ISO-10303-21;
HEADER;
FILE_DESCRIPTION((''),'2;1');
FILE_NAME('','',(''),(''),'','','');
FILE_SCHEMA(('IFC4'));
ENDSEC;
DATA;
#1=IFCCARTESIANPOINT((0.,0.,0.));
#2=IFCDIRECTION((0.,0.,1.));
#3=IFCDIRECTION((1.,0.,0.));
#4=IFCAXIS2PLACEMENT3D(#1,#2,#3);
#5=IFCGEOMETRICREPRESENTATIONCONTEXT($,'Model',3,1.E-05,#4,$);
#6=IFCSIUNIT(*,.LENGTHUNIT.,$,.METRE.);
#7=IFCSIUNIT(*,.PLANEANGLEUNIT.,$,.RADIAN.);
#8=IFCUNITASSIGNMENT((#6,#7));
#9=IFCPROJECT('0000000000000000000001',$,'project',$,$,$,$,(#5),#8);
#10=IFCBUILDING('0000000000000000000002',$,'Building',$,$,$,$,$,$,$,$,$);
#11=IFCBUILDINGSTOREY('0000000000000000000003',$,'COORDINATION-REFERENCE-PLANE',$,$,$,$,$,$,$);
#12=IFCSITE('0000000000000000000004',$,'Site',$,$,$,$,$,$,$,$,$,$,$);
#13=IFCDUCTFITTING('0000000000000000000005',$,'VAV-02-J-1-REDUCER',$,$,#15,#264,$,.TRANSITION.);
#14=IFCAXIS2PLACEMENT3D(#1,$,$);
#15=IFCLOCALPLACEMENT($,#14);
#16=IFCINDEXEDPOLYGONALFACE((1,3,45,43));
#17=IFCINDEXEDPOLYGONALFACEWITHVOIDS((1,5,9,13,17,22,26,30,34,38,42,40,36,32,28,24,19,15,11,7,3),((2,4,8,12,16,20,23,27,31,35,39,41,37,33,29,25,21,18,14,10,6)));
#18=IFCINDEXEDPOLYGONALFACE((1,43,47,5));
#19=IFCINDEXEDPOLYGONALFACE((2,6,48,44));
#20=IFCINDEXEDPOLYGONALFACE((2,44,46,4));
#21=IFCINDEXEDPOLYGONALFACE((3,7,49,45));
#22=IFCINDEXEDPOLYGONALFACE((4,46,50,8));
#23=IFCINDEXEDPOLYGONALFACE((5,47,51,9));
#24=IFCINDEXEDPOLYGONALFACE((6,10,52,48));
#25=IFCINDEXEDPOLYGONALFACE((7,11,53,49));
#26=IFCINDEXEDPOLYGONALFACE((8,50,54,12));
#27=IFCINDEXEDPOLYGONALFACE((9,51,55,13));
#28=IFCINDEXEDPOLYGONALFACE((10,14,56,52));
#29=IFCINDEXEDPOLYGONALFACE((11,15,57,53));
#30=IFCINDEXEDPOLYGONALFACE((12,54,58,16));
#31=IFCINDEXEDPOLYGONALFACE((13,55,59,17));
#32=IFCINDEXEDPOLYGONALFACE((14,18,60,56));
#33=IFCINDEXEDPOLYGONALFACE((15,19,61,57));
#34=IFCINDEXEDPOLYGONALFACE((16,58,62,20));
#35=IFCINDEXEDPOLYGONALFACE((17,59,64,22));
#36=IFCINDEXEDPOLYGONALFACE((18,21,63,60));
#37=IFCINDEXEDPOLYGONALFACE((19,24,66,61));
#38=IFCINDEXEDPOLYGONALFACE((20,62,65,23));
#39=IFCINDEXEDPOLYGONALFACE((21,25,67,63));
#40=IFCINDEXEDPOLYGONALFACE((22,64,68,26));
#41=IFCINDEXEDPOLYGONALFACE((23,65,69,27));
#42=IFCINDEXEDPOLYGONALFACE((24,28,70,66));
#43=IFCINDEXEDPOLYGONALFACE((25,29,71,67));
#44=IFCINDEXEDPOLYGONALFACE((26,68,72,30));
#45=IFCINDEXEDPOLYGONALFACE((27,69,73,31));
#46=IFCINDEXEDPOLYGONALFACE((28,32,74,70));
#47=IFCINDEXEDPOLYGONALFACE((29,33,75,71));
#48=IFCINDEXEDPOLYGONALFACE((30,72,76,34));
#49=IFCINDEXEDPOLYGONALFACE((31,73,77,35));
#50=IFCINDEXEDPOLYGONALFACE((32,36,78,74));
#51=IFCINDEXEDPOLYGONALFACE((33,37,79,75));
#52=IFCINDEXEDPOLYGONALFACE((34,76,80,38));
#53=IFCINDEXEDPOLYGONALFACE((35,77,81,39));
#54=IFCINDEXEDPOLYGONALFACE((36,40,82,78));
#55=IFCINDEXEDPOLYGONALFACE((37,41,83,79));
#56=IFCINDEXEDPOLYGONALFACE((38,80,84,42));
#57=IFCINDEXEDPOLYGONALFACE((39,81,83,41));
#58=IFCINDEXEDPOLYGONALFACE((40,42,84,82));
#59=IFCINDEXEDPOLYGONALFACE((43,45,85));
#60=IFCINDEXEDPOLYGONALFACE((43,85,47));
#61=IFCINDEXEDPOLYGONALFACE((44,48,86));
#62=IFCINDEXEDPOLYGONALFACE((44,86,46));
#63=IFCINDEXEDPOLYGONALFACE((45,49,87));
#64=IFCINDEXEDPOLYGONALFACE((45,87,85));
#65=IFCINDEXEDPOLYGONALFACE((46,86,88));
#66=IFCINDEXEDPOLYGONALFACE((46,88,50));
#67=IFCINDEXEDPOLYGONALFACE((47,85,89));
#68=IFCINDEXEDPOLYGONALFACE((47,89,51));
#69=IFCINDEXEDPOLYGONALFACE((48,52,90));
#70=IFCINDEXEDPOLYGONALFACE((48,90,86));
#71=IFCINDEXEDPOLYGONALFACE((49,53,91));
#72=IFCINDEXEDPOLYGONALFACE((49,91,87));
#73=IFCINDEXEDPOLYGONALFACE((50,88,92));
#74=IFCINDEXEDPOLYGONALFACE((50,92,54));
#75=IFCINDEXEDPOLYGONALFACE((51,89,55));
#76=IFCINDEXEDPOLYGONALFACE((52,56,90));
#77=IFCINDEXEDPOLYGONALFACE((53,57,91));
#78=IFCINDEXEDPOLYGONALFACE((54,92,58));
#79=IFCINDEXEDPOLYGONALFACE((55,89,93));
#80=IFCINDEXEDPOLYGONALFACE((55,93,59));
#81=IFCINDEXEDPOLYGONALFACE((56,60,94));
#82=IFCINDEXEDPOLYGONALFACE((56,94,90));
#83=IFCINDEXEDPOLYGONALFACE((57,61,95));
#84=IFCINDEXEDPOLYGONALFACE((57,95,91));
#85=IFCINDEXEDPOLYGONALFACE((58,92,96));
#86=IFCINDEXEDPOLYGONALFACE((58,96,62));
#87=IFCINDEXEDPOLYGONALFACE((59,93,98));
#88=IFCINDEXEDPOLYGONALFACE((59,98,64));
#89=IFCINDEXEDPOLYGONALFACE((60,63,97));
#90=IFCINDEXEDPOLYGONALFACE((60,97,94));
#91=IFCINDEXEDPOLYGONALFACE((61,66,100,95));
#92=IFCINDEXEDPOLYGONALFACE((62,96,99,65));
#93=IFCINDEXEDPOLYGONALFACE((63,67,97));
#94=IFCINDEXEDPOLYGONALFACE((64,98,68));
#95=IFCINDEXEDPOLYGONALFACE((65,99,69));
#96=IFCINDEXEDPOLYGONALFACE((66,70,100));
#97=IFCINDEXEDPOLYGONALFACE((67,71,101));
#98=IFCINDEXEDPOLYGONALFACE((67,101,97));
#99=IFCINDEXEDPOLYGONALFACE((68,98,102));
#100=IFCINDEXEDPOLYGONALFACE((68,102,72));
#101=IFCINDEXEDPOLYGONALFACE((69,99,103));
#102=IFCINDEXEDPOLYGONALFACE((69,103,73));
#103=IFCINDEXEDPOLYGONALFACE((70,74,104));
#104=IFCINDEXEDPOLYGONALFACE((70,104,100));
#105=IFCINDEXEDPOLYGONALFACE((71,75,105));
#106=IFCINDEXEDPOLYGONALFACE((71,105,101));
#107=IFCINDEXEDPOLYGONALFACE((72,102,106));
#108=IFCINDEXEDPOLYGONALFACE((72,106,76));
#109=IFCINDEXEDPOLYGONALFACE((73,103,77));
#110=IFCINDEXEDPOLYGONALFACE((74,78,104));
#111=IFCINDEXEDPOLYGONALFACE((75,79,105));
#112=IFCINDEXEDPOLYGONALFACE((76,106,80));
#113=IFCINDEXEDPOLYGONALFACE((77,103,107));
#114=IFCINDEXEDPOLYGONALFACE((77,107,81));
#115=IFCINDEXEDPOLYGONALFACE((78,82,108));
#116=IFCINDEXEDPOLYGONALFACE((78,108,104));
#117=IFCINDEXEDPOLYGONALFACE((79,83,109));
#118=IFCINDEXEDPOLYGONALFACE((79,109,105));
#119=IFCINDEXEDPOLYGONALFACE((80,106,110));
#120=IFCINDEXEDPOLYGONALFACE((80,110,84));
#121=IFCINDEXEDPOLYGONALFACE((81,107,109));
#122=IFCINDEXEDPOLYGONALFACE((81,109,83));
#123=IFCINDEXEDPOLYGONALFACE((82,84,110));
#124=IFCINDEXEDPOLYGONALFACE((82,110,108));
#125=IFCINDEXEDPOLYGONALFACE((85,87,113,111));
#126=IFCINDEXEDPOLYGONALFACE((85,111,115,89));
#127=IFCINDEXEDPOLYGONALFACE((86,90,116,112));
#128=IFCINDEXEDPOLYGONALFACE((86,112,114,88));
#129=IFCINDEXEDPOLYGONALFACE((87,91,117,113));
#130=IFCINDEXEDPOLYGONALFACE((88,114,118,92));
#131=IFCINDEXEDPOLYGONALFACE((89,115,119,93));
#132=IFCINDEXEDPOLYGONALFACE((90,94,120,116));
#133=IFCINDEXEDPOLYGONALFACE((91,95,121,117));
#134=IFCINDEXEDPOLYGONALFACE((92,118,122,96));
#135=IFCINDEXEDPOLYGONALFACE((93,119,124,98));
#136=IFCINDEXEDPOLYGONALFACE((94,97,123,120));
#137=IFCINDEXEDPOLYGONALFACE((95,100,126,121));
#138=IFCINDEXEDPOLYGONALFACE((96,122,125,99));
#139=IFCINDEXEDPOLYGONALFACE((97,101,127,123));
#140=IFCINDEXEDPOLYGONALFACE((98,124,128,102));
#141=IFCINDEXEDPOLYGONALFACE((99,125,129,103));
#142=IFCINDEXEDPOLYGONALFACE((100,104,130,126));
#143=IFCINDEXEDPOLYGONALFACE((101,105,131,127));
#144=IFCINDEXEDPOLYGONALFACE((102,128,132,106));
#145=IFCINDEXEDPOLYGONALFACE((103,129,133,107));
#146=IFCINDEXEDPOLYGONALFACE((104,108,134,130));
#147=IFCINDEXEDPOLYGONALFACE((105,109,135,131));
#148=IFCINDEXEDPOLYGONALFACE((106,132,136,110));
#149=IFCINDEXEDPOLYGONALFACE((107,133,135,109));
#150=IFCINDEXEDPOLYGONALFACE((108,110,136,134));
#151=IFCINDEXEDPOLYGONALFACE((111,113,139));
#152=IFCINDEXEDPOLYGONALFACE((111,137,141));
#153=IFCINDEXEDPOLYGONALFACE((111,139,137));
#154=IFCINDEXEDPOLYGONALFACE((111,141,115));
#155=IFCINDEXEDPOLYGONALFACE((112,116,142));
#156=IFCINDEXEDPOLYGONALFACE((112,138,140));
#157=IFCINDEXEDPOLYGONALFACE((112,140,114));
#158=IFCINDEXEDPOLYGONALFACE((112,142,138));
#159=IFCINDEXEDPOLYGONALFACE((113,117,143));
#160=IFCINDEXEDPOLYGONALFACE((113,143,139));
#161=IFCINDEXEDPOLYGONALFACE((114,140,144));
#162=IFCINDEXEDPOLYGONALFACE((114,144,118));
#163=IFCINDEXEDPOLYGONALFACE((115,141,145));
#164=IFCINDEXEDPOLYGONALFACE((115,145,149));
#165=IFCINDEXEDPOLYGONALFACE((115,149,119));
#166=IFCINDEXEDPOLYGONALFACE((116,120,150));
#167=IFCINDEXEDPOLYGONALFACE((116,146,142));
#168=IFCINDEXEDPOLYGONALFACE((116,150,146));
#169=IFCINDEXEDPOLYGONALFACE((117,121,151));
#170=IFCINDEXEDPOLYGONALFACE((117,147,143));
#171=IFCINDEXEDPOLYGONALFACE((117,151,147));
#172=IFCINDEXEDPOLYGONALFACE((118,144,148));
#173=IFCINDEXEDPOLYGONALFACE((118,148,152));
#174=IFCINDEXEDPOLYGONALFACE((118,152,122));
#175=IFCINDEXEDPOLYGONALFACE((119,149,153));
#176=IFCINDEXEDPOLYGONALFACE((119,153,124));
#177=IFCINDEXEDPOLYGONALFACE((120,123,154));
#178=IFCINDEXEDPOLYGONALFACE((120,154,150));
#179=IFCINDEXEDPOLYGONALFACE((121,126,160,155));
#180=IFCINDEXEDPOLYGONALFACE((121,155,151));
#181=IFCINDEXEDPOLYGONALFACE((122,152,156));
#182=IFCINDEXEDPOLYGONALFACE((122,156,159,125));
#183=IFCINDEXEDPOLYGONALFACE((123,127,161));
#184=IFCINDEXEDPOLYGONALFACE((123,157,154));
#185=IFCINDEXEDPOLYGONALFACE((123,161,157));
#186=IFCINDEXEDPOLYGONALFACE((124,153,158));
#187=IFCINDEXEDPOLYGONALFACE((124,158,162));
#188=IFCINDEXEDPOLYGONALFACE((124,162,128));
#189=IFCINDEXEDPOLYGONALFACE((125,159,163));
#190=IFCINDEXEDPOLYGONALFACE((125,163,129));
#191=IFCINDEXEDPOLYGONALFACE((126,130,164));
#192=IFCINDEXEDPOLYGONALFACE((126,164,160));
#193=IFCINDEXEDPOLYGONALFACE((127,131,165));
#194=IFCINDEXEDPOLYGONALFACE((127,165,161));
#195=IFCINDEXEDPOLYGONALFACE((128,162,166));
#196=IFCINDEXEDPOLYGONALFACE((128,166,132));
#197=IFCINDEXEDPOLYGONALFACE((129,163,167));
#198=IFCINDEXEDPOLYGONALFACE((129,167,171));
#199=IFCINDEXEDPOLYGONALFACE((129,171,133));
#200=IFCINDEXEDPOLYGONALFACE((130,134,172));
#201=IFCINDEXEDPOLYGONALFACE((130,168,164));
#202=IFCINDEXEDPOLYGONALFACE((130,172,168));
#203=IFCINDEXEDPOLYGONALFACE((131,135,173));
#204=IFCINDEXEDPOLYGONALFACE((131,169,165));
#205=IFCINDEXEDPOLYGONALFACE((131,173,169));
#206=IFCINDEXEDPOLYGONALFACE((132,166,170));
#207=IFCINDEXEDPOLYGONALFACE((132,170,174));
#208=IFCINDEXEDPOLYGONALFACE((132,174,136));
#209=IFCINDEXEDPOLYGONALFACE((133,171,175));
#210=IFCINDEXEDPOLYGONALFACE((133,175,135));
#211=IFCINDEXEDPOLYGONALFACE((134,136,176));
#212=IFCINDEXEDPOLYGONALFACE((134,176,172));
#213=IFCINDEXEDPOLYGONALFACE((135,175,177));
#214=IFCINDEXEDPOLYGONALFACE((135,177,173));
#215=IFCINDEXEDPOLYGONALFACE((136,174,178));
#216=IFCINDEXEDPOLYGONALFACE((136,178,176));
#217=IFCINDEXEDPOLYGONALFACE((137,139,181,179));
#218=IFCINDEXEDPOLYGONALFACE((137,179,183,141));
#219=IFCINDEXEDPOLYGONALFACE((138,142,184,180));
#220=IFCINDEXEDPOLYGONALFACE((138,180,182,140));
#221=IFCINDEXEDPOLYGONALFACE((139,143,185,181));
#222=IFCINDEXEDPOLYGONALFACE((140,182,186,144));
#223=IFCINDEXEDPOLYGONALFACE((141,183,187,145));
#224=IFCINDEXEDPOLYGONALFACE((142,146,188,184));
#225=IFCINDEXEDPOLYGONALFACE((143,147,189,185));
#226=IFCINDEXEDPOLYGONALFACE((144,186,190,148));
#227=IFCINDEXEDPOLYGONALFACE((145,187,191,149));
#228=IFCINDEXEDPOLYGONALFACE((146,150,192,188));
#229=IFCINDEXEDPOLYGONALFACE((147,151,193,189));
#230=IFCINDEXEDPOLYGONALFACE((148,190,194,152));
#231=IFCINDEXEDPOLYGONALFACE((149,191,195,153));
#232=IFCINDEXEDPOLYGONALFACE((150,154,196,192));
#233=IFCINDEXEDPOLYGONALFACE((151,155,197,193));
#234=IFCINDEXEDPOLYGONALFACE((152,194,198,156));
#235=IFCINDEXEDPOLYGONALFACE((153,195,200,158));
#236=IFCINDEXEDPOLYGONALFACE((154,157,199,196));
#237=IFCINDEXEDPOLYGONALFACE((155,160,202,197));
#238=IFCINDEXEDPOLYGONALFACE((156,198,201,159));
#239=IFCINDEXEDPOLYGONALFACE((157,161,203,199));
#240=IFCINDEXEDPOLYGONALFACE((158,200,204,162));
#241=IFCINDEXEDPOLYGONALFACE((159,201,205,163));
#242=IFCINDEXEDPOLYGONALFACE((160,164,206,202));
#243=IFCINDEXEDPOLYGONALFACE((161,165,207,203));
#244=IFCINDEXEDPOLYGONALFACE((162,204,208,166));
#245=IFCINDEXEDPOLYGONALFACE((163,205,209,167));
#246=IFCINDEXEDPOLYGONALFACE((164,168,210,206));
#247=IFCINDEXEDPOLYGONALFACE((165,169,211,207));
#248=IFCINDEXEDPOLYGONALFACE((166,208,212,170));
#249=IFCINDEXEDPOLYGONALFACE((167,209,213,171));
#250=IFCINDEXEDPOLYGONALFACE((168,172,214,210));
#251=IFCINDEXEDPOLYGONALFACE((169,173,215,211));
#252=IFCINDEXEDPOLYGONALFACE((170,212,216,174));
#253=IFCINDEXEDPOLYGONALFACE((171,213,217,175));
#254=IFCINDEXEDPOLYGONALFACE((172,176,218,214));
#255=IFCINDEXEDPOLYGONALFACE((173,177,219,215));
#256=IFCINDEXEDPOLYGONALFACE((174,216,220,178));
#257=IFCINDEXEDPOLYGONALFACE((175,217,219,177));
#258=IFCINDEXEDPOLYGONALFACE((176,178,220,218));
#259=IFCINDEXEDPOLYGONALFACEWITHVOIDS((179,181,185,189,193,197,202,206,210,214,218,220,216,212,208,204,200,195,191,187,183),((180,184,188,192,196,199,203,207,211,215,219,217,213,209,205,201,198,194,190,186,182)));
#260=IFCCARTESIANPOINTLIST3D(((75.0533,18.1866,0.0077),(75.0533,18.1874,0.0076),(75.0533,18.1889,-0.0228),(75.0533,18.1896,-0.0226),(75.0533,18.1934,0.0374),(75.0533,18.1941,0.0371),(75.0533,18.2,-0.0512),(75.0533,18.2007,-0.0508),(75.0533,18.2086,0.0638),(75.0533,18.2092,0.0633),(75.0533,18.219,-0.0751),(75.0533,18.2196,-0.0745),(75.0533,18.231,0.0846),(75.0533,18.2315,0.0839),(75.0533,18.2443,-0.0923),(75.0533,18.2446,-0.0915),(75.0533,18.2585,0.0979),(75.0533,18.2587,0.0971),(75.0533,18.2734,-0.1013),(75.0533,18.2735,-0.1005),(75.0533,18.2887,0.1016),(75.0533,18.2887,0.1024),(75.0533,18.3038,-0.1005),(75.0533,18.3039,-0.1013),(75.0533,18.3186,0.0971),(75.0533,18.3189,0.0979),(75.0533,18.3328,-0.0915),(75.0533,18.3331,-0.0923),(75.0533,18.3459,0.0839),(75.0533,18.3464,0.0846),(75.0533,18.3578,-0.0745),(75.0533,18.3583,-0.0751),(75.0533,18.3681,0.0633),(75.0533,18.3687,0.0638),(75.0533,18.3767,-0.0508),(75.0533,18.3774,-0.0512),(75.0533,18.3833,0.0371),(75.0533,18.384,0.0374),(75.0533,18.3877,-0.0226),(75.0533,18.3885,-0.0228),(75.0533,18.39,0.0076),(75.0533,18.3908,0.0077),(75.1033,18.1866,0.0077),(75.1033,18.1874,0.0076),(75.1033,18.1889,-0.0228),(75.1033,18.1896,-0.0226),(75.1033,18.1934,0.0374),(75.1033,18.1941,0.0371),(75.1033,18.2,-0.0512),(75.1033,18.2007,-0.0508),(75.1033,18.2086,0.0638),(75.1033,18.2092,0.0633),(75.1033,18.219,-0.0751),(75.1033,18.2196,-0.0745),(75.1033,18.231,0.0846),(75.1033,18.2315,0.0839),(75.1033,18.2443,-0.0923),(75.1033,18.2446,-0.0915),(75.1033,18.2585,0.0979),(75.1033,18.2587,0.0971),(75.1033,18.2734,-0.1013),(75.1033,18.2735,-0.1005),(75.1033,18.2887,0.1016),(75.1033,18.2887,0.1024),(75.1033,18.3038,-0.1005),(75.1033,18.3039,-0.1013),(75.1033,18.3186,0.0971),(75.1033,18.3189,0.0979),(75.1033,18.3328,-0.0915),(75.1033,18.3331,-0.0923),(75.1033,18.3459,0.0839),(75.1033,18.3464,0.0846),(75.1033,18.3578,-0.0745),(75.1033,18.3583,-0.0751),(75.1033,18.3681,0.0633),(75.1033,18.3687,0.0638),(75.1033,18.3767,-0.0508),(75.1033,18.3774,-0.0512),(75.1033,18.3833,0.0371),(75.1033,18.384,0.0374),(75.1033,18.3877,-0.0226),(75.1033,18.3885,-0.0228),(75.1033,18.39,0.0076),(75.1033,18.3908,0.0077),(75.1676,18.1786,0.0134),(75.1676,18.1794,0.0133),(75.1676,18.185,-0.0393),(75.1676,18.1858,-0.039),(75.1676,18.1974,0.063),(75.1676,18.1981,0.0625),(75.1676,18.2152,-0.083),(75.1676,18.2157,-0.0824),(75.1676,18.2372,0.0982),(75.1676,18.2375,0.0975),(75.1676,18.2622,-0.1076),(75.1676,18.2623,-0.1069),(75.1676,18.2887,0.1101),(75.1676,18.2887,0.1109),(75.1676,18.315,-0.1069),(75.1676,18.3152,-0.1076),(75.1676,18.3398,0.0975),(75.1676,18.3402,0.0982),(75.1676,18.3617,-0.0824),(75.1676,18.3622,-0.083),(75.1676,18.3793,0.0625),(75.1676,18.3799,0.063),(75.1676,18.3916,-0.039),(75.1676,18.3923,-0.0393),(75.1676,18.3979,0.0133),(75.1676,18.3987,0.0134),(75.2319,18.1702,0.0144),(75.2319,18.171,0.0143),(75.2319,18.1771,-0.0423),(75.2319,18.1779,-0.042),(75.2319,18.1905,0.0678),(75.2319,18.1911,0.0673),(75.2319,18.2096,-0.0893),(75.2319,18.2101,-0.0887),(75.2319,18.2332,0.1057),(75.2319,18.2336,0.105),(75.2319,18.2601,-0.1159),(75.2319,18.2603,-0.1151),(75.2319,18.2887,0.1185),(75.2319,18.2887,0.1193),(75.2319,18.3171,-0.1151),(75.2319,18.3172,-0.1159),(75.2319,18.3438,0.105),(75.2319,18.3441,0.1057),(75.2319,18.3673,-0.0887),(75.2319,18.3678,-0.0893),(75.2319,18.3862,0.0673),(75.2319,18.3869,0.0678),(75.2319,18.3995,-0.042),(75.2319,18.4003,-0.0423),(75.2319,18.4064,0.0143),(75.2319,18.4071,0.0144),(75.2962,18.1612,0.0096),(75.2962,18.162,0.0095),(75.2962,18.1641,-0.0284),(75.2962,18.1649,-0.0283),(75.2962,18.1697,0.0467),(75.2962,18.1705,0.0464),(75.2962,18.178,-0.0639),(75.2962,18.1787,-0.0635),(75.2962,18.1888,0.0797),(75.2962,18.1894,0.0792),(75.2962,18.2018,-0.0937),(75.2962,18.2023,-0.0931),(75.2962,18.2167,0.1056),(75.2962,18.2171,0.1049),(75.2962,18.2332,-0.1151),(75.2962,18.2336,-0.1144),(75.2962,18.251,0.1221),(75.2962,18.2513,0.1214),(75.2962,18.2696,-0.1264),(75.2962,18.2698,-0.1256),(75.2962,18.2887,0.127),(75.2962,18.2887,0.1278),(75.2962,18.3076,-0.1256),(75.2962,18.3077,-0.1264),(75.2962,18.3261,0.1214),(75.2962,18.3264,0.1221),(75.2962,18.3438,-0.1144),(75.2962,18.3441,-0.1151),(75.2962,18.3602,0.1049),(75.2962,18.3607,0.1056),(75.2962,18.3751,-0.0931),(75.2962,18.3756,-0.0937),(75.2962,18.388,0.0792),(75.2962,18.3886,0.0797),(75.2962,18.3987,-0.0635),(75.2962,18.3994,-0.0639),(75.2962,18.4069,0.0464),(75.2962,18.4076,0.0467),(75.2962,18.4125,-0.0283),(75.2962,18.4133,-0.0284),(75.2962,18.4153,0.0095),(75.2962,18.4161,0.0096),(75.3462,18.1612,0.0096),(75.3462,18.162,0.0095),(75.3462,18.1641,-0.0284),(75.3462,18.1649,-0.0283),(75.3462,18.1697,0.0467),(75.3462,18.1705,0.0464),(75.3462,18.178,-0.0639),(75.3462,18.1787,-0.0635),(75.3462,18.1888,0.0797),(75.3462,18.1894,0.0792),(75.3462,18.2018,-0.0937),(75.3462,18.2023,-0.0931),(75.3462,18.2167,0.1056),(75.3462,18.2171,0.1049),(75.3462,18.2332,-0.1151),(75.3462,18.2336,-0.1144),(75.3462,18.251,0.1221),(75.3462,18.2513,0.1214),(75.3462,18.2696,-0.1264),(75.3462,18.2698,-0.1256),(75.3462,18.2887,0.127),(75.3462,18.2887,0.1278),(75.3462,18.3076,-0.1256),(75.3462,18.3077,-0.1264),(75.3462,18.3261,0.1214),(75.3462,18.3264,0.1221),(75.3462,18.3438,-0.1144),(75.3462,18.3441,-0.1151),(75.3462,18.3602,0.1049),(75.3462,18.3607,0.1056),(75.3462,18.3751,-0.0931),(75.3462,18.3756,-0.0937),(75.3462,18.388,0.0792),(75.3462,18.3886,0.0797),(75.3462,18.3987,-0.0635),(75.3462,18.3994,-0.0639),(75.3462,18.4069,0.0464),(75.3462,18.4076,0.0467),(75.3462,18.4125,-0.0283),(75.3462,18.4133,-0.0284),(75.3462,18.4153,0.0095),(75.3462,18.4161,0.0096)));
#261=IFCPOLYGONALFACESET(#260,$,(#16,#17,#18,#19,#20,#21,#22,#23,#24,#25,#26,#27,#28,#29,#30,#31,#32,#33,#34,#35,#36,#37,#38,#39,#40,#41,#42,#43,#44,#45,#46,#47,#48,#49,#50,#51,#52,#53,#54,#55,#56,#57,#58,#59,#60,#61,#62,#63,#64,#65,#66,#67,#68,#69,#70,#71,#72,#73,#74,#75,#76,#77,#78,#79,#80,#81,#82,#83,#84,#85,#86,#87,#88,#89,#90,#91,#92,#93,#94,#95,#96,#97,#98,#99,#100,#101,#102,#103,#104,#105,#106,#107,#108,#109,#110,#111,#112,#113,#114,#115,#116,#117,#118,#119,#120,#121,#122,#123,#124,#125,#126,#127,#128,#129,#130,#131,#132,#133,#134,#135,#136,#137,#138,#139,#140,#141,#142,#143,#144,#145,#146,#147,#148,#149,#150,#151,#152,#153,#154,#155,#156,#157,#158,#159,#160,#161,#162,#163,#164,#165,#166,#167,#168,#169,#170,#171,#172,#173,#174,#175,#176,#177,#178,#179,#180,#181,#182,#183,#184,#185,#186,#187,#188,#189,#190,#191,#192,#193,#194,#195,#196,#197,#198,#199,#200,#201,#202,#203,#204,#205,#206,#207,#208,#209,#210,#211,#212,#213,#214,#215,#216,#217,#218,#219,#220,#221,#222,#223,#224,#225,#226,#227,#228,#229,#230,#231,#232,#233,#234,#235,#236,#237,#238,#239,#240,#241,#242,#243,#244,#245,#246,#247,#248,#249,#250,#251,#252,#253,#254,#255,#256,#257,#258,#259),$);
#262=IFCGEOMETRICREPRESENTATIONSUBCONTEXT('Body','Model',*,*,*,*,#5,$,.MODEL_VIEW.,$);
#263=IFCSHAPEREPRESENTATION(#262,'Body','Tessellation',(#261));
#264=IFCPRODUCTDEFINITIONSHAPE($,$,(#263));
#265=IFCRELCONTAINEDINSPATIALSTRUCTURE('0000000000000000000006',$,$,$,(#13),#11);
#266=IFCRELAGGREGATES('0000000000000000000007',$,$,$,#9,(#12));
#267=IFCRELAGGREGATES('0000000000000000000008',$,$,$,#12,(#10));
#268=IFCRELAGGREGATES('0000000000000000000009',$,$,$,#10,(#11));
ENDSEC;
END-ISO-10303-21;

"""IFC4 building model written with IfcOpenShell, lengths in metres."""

from ifc_helpers import new_model, entity, si_unit, frame, origin_with_axes, place, context, subcontext, project, spatial, element, save


model = new_model("IFC4")

# Units and contexts
model_context = context("Model", 3, precision=1e-05, world=origin_with_axes())
body_context_1 = subcontext(model_context, "Body", "Model", "MODEL_VIEW")
ifc_project = project(units=[si_unit("LENGTHUNIT", "METRE"), si_unit("PLANEANGLEUNIT", "RADIAN")], contexts=[model_context])

# Site, building, storey
site = spatial("IfcSite", under=ifc_project, Name="Site")
building = spatial("IfcBuilding", under=site, Name="Building")
storey = spatial("IfcBuildingStorey", under=building, Name="COORDINATION-REFERENCE-PLANE")

# Duct fitting
for number, where, z_axis, x_axis, name in (
    (1, (75.3462, 18.2887, 0.0), (0.0, -1.0, 0.0), (0.0, 0.0, 1.0), "VAV-02-J-1-REDUCER"),
):
    element("IfcDuctFitting", number, at=place(None, frame(where, z_axis=z_axis, x_axis=x_axis)), inside=storey, Name=name, PredefinedType="TRANSITION", context=body_context_1, shape_type="SweptSolid", body=[
        entity("IfcRevolvedAreaSolid", entity("IfcArbitraryClosedProfileDef", "AREA", None, entity("IfcPolyline", [entity("IfcCartesianPoint", [0.1278, 0.0]), entity("IfcCartesianPoint", [0.1278, 0.05]), entity("IfcCartesianPoint", [0.1024, 0.2429]), entity("IfcCartesianPoint", [0.1024, 0.2929]), entity("IfcCartesianPoint", [0.1016, 0.2929]), entity("IfcCartesianPoint", [0.1016, 0.2429]), entity("IfcCartesianPoint", [0.127, 0.05]), entity("IfcCartesianPoint", [0.127, 0.0]), entity("IfcCartesianPoint", [0.1278, 0.0])])), entity("IfcAxis2Placement3D", entity("IfcCartesianPoint", [0.0, 0.0, 0.0])), entity("IfcAxis1Placement", entity("IfcCartesianPoint", [0.0, 0.0, 0.0]), entity("IfcDirection", [0.0, 1.0, 0.0])), 6.283185),
    ])

save(model, "model.ifc")
